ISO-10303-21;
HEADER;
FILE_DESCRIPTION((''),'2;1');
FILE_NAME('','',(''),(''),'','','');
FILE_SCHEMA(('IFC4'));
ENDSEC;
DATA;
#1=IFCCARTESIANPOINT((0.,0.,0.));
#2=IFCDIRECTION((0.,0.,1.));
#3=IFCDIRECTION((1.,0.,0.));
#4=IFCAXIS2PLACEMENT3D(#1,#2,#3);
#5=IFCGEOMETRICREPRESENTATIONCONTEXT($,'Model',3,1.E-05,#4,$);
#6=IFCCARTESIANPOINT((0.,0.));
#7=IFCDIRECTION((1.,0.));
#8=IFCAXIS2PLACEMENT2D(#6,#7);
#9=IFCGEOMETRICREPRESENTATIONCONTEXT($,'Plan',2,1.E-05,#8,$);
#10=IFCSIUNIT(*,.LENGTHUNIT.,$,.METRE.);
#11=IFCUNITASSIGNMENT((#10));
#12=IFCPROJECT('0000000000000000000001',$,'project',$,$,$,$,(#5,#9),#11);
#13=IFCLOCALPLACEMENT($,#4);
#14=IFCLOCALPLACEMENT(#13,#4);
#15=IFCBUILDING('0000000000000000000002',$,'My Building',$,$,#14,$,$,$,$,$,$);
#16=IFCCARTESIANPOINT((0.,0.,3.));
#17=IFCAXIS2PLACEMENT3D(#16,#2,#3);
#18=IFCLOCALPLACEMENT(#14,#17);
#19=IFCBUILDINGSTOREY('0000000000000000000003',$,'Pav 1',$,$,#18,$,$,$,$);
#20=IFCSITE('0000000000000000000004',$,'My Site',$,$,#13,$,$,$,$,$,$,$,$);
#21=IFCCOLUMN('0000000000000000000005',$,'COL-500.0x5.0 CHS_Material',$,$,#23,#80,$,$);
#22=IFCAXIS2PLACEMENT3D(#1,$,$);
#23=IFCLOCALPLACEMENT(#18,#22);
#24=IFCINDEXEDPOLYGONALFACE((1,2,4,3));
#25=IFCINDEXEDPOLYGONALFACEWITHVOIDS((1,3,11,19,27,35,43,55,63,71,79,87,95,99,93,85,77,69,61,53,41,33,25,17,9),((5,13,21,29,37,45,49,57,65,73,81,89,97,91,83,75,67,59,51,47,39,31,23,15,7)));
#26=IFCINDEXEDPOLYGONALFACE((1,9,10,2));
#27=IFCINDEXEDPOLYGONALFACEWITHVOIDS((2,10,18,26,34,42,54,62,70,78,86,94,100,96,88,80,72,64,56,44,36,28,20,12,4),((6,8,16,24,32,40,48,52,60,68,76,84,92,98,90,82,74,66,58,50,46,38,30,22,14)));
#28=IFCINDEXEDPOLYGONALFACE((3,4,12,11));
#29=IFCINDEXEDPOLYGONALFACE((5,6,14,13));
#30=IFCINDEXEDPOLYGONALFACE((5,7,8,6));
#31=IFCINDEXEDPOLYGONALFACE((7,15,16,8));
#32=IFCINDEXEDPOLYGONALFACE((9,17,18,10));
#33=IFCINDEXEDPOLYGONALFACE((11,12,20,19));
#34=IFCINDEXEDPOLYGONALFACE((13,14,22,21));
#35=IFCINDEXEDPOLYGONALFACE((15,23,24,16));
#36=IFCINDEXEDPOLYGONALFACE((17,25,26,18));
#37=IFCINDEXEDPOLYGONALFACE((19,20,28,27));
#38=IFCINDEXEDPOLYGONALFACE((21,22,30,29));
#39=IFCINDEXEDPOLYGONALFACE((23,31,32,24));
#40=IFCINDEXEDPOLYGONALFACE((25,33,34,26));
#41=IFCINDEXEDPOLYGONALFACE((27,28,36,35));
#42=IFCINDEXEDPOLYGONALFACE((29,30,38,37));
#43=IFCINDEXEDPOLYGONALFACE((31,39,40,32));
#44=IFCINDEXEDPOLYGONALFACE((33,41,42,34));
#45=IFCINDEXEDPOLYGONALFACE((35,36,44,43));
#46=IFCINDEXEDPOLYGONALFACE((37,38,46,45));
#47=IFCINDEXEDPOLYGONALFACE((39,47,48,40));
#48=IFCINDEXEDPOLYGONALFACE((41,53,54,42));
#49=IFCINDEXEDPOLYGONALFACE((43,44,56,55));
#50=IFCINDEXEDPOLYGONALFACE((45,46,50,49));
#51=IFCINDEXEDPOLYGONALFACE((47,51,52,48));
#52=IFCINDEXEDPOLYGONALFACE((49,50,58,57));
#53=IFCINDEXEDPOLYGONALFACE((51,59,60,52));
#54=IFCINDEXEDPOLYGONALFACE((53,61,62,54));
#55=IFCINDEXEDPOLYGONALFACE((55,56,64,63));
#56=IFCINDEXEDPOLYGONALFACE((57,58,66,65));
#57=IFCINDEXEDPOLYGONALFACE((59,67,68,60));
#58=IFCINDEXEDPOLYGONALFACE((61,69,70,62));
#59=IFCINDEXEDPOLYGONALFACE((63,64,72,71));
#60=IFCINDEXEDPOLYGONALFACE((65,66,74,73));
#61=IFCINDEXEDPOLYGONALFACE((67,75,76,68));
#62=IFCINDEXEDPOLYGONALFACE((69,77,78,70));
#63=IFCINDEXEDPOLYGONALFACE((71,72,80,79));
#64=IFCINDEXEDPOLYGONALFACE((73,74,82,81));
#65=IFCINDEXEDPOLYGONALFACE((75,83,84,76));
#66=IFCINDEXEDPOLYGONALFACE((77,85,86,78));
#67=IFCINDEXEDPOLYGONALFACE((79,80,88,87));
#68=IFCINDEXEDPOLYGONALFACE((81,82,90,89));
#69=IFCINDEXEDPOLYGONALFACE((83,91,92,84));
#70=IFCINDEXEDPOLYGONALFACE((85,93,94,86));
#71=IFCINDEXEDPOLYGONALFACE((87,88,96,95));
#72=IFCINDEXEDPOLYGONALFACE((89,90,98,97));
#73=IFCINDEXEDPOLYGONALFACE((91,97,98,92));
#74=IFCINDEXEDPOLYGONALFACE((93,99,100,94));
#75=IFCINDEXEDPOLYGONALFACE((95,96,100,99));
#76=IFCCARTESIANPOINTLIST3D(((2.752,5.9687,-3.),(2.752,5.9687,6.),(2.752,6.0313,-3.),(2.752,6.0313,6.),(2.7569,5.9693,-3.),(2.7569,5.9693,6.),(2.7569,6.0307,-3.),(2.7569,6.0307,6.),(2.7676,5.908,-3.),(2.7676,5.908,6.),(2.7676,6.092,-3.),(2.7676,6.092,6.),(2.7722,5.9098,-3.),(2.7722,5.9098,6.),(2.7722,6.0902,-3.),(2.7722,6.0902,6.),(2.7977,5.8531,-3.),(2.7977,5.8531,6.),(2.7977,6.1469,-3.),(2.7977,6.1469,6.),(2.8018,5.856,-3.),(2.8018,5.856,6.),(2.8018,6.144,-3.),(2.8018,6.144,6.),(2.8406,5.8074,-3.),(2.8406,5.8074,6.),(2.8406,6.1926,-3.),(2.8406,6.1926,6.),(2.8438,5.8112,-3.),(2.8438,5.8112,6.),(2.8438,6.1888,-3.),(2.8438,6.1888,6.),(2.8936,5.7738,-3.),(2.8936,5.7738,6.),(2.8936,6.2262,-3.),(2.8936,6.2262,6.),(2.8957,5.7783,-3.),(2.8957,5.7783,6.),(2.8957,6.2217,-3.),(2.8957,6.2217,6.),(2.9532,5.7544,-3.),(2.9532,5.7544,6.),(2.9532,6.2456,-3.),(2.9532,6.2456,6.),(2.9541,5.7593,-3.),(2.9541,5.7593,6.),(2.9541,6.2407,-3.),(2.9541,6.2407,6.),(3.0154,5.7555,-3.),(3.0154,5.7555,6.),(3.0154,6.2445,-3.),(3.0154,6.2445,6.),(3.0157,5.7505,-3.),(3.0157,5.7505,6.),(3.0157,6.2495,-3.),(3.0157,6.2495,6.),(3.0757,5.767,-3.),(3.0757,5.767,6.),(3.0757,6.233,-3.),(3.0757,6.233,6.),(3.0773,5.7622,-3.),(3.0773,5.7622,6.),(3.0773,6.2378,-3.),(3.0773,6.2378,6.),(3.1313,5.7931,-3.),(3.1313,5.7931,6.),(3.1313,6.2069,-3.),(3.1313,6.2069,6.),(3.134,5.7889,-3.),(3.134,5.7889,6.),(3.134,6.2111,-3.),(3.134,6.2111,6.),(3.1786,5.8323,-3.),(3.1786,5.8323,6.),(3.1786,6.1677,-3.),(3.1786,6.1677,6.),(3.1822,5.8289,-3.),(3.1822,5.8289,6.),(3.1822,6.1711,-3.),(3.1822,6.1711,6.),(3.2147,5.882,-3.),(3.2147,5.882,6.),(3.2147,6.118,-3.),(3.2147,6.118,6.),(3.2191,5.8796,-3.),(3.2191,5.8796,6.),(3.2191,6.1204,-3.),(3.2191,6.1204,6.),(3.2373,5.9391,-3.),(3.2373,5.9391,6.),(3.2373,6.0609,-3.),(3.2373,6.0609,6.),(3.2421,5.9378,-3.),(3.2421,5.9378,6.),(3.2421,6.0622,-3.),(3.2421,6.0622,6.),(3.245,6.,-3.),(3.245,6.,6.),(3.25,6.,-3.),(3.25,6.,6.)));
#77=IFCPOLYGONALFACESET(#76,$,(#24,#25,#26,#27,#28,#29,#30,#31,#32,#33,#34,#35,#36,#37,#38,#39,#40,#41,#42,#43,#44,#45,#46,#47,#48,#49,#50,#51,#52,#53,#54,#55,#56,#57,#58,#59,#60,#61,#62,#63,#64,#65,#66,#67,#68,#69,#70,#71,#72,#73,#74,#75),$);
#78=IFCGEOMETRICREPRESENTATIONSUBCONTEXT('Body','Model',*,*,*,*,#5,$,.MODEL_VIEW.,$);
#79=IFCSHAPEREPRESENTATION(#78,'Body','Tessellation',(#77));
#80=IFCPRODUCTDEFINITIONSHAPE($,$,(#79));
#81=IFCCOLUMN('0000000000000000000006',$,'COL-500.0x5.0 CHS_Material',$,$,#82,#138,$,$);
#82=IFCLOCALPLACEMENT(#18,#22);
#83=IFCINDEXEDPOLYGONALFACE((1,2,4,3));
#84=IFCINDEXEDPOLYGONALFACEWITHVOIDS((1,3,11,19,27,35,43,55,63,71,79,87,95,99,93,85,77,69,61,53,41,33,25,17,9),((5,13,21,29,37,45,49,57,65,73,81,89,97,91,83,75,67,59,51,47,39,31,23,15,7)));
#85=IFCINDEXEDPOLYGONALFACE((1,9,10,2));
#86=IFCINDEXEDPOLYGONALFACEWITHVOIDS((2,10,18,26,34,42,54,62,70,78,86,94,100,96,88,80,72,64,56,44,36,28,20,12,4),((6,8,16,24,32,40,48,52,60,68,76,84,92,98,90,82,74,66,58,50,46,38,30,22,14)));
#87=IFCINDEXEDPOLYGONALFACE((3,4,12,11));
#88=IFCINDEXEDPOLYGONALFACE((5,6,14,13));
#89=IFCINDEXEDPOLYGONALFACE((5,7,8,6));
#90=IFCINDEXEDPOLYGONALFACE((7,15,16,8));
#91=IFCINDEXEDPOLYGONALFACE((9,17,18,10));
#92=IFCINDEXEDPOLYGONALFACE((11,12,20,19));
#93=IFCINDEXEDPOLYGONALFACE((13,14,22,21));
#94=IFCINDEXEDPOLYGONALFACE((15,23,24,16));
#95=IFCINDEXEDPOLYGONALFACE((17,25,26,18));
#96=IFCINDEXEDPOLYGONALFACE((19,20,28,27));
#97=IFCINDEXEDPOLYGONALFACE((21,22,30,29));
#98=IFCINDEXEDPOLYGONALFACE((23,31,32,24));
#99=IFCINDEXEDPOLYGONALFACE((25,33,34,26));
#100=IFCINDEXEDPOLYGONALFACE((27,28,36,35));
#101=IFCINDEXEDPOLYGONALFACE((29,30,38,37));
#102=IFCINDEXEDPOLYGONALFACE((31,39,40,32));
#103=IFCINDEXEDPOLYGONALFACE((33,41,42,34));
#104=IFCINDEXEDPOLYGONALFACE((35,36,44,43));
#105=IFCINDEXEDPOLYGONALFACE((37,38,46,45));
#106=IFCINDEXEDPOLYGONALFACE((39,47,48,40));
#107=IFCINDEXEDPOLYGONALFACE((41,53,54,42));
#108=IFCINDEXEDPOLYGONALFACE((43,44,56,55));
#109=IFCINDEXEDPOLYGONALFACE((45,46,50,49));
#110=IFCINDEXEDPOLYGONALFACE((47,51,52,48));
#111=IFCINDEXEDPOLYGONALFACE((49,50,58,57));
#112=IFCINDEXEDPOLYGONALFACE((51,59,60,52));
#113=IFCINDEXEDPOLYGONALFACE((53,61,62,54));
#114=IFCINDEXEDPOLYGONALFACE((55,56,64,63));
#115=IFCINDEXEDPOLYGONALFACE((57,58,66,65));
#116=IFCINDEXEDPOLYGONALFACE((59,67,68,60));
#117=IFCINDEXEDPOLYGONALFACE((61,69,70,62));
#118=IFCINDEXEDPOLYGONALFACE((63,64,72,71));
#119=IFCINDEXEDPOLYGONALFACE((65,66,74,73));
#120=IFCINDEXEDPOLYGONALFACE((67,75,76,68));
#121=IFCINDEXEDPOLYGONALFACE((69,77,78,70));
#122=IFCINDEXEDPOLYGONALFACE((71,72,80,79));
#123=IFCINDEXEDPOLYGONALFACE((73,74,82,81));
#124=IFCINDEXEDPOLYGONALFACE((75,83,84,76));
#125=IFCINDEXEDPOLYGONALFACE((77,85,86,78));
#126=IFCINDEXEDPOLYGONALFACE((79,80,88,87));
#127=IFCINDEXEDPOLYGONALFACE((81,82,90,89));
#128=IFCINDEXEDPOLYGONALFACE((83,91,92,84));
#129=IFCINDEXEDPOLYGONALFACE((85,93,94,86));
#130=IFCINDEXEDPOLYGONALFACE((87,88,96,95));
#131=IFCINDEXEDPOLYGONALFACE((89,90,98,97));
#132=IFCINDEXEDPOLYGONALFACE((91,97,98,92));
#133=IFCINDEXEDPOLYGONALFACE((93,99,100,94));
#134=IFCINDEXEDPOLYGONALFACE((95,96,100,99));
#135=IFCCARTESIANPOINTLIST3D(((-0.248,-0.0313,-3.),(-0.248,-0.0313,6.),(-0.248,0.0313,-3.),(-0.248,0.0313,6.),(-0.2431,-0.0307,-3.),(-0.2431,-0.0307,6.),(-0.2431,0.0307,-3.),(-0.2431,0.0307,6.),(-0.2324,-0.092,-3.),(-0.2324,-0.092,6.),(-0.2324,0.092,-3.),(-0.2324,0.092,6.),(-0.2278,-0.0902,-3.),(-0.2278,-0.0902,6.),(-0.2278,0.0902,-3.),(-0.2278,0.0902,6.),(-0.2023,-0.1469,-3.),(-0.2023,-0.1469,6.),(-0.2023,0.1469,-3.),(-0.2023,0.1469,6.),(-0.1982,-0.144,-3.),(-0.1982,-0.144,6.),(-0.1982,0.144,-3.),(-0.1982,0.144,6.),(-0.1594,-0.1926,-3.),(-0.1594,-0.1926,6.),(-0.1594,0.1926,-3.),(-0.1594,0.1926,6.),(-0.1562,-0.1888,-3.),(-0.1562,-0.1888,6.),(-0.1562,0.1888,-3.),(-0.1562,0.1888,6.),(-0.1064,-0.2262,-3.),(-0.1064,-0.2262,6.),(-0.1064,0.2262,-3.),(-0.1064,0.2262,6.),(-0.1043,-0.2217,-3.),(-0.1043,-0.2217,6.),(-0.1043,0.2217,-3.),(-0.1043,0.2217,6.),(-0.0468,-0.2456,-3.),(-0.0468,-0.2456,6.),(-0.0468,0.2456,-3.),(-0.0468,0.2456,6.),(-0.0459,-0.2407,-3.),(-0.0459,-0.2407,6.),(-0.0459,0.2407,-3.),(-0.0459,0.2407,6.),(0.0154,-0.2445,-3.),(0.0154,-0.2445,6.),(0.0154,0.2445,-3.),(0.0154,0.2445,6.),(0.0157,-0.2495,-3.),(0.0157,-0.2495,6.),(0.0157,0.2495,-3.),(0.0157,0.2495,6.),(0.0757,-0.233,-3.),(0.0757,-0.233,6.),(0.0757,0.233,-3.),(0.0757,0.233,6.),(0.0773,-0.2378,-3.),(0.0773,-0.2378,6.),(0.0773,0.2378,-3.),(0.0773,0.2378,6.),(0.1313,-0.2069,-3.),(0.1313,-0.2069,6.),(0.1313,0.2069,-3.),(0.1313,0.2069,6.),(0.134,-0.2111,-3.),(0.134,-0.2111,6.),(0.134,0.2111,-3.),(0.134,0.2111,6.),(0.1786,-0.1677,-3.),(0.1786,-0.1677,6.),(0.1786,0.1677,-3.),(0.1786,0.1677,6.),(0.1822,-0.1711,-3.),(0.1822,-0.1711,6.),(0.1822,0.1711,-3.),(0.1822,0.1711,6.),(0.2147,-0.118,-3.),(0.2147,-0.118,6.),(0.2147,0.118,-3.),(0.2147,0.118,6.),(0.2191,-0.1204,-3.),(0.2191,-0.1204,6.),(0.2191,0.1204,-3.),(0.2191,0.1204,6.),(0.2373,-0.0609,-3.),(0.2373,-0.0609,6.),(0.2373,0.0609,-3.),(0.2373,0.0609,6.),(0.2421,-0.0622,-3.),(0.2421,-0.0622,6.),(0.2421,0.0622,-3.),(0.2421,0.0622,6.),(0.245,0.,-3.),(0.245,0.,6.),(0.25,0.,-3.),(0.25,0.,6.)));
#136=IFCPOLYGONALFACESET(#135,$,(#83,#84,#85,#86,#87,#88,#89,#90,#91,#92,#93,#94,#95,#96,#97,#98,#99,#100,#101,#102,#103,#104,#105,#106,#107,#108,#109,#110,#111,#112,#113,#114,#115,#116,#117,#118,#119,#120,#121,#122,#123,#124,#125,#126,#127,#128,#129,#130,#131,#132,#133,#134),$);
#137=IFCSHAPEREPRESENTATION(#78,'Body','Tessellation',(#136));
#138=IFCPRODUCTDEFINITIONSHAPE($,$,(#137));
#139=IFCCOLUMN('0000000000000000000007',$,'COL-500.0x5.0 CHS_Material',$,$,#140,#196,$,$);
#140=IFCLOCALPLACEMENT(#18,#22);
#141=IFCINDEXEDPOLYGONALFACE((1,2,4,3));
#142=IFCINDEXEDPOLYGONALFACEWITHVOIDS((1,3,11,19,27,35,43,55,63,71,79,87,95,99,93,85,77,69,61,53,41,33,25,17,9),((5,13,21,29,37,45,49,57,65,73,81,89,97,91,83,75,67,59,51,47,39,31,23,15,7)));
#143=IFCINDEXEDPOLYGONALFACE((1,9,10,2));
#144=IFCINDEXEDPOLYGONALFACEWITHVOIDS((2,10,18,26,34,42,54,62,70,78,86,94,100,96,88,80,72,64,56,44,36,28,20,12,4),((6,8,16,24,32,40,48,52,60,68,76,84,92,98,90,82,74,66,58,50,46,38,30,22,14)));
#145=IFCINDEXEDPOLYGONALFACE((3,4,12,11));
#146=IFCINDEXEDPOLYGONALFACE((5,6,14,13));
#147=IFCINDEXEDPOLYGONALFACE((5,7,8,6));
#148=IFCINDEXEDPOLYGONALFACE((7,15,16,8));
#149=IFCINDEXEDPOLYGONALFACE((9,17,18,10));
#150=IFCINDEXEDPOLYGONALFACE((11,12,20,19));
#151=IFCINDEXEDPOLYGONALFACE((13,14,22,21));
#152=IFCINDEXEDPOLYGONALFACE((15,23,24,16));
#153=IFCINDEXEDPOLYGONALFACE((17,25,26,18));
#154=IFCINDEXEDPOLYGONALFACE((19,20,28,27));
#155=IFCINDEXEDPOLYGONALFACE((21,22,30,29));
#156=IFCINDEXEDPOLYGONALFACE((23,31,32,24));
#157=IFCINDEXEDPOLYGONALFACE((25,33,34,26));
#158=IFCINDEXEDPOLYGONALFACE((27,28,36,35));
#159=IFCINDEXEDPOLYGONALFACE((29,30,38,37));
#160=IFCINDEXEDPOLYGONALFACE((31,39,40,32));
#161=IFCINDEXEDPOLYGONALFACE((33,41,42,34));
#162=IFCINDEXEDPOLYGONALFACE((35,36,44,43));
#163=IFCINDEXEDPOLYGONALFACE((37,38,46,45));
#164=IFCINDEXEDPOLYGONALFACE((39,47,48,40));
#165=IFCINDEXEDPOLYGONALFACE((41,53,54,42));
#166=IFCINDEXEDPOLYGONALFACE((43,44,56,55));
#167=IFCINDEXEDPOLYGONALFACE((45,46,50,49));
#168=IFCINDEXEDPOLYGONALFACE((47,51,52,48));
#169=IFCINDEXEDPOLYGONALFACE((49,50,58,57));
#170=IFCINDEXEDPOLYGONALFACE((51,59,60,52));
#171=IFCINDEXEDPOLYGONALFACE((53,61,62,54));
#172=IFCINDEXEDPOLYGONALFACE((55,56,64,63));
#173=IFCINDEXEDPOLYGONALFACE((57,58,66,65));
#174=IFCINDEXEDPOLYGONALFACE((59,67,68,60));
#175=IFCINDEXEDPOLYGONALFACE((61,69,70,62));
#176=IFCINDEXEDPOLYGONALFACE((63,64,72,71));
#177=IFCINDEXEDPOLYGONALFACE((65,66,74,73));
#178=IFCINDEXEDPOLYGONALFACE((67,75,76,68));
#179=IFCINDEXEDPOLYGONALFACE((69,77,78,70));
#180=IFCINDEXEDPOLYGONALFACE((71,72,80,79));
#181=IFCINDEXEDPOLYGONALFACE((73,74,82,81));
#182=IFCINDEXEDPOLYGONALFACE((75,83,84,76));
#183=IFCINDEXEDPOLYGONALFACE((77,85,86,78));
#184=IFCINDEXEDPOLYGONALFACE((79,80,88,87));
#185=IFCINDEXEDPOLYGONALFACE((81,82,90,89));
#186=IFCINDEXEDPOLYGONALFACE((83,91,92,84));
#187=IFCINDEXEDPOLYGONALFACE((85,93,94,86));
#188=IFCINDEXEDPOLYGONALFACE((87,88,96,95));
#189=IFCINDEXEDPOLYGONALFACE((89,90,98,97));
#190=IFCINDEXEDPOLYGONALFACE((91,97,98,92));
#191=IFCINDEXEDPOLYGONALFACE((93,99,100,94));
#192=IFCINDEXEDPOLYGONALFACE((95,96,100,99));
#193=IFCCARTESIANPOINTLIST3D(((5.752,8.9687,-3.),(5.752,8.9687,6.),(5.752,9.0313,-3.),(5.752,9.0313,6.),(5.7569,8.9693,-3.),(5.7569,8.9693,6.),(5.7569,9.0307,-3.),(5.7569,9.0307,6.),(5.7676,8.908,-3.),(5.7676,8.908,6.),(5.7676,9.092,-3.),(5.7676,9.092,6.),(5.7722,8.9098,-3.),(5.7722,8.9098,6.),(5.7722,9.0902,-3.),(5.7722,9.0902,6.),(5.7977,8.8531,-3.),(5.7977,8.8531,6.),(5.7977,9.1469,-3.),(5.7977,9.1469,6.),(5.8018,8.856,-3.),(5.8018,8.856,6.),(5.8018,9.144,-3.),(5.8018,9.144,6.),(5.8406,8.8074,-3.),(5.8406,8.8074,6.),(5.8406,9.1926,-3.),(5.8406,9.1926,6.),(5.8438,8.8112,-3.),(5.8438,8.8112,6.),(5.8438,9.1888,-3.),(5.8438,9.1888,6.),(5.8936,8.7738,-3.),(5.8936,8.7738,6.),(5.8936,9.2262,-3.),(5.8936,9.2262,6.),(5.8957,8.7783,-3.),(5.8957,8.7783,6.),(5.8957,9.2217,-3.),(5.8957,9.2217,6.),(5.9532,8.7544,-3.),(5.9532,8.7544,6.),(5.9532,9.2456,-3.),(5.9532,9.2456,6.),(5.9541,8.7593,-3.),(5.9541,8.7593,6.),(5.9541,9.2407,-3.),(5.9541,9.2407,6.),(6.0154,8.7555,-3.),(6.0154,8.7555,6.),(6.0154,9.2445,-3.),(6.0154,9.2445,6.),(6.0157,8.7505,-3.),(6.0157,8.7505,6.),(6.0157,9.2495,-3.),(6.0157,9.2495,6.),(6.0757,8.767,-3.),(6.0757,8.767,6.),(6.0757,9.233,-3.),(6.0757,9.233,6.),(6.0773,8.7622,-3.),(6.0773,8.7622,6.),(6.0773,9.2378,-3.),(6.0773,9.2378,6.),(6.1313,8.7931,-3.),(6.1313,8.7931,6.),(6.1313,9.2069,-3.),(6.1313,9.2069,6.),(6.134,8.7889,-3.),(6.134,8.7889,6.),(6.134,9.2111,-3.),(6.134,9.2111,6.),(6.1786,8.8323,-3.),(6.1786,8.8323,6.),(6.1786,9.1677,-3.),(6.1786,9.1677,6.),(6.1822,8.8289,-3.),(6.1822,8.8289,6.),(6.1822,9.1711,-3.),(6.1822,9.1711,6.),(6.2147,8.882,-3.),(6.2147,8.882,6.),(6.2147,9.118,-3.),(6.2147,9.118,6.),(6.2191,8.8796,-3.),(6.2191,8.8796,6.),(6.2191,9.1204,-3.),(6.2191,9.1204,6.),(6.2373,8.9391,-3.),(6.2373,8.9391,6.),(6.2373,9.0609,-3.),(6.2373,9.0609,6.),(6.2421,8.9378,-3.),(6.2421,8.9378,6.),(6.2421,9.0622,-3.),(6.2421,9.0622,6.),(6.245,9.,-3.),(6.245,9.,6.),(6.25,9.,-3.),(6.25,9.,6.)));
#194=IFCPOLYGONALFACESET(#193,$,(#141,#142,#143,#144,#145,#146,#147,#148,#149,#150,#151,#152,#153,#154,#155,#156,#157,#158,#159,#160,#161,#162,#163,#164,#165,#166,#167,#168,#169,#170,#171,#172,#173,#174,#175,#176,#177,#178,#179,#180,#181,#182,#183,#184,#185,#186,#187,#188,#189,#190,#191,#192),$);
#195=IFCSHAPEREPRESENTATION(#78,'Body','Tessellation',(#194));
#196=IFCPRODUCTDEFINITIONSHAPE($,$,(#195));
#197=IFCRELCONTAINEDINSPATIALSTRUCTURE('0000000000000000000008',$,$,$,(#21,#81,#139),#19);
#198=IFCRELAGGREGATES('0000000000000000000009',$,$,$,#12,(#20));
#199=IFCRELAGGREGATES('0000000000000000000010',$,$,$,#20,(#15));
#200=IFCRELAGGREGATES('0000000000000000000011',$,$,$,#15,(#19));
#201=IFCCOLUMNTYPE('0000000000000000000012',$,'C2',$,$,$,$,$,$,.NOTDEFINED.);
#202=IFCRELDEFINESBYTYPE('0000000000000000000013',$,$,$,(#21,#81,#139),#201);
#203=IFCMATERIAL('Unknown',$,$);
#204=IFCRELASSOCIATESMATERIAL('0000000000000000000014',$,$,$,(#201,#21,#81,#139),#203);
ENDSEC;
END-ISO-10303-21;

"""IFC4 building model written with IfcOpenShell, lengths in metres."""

from ifc_helpers import new_model, si_unit, frame, origin, origin_with_axes, origin_2d_with_axis, place, context, subcontext, project, spatial, hollow_circle, extrude, material, material_profile, profile_set, profile_usage, type_object, element, save


model = new_model("IFC4")

# Units and contexts
model_context = context("Model", 3, precision=1e-05, world=origin_with_axes())
plan_context = context("Plan", 2, precision=1e-05, world=origin_2d_with_axis())
body_context = subcontext(model_context, "Body", "Model", "MODEL_VIEW")
ifc_project = project(units=[si_unit("LENGTHUNIT", "METRE")], contexts=[model_context, plan_context])

# Site, building, storey
site_placement = place(None, origin_with_axes())
site = spatial("IfcSite", under=ifc_project, at=site_placement, Name="My Site")
building_placement = place(site_placement, origin_with_axes())
building = spatial("IfcBuilding", under=site, at=building_placement, Name="My Building")
storey_placement = place(building_placement, frame((0.0, 0.0, 3.0), z_axis=(0.0, 0.0, 1.0), x_axis=(1.0, 0.0, 0.0)))
storey = spatial("IfcBuildingStorey", under=building, at=storey_placement, Name="Pav 1")

# Columns
ifc_material = material(Name="Unknown")
ifc_material_profile = material_profile(ifc_material, hollow_circle(Radius=0.25, WallThickness=0.005))
ifc_profile_set = profile_set([ifc_material_profile])
column_type = type_object("IfcColumnType", Name="C2", PredefinedType="NOTDEFINED", material=ifc_profile_set)
ifc_profile_usage_1 = profile_usage(ifc_profile_set, cardinal=5)
column_1_placement = place(storey_placement, frame((3.0, 6.0, -3.0), z_axis=(0.0, 0.0, 1.0), x_axis=(1.0, 0.0, 0.0)))
element("IfcColumn", 1, at=column_1_placement, inside=storey, type_object=column_type, material=ifc_profile_usage_1, Name="COL-500.0x5.0 CHS_Material", context=body_context, shape_type="SweptSolid", body=[
    extrude(hollow_circle(Radius=0.25, WallThickness=0.005), origin(), (0.0, 0.0, 1.0), 9.0),
])
ifc_profile_usage_2 = profile_usage(ifc_profile_set, cardinal=5)
column_2_placement = place(storey_placement, frame((0.0, 0.0, -3.0), z_axis=(0.0, 0.0, 1.0), x_axis=(1.0, 0.0, 0.0)))
element("IfcColumn", 2, at=column_2_placement, inside=storey, type_object=column_type, material=ifc_profile_usage_2, Name="COL-500.0x5.0 CHS_Material", context=body_context, shape_type="SweptSolid", body=[
    extrude(hollow_circle(Radius=0.25, WallThickness=0.005), origin(), (0.0, 0.0, 1.0), 9.0),
])
ifc_profile_usage_3 = profile_usage(ifc_profile_set, cardinal=5)
column_3_placement = place(storey_placement, frame((6.0, 9.0, -3.0), z_axis=(0.0, 0.0, 1.0), x_axis=(1.0, 0.0, 0.0)))
element("IfcColumn", 3, at=column_3_placement, inside=storey, type_object=column_type, material=ifc_profile_usage_3, Name="COL-500.0x5.0 CHS_Material", context=body_context, shape_type="SweptSolid", body=[
    extrude(hollow_circle(Radius=0.25, WallThickness=0.005), origin(), (0.0, 0.0, 1.0), 9.0),
])

save(model, "model.ifc")
